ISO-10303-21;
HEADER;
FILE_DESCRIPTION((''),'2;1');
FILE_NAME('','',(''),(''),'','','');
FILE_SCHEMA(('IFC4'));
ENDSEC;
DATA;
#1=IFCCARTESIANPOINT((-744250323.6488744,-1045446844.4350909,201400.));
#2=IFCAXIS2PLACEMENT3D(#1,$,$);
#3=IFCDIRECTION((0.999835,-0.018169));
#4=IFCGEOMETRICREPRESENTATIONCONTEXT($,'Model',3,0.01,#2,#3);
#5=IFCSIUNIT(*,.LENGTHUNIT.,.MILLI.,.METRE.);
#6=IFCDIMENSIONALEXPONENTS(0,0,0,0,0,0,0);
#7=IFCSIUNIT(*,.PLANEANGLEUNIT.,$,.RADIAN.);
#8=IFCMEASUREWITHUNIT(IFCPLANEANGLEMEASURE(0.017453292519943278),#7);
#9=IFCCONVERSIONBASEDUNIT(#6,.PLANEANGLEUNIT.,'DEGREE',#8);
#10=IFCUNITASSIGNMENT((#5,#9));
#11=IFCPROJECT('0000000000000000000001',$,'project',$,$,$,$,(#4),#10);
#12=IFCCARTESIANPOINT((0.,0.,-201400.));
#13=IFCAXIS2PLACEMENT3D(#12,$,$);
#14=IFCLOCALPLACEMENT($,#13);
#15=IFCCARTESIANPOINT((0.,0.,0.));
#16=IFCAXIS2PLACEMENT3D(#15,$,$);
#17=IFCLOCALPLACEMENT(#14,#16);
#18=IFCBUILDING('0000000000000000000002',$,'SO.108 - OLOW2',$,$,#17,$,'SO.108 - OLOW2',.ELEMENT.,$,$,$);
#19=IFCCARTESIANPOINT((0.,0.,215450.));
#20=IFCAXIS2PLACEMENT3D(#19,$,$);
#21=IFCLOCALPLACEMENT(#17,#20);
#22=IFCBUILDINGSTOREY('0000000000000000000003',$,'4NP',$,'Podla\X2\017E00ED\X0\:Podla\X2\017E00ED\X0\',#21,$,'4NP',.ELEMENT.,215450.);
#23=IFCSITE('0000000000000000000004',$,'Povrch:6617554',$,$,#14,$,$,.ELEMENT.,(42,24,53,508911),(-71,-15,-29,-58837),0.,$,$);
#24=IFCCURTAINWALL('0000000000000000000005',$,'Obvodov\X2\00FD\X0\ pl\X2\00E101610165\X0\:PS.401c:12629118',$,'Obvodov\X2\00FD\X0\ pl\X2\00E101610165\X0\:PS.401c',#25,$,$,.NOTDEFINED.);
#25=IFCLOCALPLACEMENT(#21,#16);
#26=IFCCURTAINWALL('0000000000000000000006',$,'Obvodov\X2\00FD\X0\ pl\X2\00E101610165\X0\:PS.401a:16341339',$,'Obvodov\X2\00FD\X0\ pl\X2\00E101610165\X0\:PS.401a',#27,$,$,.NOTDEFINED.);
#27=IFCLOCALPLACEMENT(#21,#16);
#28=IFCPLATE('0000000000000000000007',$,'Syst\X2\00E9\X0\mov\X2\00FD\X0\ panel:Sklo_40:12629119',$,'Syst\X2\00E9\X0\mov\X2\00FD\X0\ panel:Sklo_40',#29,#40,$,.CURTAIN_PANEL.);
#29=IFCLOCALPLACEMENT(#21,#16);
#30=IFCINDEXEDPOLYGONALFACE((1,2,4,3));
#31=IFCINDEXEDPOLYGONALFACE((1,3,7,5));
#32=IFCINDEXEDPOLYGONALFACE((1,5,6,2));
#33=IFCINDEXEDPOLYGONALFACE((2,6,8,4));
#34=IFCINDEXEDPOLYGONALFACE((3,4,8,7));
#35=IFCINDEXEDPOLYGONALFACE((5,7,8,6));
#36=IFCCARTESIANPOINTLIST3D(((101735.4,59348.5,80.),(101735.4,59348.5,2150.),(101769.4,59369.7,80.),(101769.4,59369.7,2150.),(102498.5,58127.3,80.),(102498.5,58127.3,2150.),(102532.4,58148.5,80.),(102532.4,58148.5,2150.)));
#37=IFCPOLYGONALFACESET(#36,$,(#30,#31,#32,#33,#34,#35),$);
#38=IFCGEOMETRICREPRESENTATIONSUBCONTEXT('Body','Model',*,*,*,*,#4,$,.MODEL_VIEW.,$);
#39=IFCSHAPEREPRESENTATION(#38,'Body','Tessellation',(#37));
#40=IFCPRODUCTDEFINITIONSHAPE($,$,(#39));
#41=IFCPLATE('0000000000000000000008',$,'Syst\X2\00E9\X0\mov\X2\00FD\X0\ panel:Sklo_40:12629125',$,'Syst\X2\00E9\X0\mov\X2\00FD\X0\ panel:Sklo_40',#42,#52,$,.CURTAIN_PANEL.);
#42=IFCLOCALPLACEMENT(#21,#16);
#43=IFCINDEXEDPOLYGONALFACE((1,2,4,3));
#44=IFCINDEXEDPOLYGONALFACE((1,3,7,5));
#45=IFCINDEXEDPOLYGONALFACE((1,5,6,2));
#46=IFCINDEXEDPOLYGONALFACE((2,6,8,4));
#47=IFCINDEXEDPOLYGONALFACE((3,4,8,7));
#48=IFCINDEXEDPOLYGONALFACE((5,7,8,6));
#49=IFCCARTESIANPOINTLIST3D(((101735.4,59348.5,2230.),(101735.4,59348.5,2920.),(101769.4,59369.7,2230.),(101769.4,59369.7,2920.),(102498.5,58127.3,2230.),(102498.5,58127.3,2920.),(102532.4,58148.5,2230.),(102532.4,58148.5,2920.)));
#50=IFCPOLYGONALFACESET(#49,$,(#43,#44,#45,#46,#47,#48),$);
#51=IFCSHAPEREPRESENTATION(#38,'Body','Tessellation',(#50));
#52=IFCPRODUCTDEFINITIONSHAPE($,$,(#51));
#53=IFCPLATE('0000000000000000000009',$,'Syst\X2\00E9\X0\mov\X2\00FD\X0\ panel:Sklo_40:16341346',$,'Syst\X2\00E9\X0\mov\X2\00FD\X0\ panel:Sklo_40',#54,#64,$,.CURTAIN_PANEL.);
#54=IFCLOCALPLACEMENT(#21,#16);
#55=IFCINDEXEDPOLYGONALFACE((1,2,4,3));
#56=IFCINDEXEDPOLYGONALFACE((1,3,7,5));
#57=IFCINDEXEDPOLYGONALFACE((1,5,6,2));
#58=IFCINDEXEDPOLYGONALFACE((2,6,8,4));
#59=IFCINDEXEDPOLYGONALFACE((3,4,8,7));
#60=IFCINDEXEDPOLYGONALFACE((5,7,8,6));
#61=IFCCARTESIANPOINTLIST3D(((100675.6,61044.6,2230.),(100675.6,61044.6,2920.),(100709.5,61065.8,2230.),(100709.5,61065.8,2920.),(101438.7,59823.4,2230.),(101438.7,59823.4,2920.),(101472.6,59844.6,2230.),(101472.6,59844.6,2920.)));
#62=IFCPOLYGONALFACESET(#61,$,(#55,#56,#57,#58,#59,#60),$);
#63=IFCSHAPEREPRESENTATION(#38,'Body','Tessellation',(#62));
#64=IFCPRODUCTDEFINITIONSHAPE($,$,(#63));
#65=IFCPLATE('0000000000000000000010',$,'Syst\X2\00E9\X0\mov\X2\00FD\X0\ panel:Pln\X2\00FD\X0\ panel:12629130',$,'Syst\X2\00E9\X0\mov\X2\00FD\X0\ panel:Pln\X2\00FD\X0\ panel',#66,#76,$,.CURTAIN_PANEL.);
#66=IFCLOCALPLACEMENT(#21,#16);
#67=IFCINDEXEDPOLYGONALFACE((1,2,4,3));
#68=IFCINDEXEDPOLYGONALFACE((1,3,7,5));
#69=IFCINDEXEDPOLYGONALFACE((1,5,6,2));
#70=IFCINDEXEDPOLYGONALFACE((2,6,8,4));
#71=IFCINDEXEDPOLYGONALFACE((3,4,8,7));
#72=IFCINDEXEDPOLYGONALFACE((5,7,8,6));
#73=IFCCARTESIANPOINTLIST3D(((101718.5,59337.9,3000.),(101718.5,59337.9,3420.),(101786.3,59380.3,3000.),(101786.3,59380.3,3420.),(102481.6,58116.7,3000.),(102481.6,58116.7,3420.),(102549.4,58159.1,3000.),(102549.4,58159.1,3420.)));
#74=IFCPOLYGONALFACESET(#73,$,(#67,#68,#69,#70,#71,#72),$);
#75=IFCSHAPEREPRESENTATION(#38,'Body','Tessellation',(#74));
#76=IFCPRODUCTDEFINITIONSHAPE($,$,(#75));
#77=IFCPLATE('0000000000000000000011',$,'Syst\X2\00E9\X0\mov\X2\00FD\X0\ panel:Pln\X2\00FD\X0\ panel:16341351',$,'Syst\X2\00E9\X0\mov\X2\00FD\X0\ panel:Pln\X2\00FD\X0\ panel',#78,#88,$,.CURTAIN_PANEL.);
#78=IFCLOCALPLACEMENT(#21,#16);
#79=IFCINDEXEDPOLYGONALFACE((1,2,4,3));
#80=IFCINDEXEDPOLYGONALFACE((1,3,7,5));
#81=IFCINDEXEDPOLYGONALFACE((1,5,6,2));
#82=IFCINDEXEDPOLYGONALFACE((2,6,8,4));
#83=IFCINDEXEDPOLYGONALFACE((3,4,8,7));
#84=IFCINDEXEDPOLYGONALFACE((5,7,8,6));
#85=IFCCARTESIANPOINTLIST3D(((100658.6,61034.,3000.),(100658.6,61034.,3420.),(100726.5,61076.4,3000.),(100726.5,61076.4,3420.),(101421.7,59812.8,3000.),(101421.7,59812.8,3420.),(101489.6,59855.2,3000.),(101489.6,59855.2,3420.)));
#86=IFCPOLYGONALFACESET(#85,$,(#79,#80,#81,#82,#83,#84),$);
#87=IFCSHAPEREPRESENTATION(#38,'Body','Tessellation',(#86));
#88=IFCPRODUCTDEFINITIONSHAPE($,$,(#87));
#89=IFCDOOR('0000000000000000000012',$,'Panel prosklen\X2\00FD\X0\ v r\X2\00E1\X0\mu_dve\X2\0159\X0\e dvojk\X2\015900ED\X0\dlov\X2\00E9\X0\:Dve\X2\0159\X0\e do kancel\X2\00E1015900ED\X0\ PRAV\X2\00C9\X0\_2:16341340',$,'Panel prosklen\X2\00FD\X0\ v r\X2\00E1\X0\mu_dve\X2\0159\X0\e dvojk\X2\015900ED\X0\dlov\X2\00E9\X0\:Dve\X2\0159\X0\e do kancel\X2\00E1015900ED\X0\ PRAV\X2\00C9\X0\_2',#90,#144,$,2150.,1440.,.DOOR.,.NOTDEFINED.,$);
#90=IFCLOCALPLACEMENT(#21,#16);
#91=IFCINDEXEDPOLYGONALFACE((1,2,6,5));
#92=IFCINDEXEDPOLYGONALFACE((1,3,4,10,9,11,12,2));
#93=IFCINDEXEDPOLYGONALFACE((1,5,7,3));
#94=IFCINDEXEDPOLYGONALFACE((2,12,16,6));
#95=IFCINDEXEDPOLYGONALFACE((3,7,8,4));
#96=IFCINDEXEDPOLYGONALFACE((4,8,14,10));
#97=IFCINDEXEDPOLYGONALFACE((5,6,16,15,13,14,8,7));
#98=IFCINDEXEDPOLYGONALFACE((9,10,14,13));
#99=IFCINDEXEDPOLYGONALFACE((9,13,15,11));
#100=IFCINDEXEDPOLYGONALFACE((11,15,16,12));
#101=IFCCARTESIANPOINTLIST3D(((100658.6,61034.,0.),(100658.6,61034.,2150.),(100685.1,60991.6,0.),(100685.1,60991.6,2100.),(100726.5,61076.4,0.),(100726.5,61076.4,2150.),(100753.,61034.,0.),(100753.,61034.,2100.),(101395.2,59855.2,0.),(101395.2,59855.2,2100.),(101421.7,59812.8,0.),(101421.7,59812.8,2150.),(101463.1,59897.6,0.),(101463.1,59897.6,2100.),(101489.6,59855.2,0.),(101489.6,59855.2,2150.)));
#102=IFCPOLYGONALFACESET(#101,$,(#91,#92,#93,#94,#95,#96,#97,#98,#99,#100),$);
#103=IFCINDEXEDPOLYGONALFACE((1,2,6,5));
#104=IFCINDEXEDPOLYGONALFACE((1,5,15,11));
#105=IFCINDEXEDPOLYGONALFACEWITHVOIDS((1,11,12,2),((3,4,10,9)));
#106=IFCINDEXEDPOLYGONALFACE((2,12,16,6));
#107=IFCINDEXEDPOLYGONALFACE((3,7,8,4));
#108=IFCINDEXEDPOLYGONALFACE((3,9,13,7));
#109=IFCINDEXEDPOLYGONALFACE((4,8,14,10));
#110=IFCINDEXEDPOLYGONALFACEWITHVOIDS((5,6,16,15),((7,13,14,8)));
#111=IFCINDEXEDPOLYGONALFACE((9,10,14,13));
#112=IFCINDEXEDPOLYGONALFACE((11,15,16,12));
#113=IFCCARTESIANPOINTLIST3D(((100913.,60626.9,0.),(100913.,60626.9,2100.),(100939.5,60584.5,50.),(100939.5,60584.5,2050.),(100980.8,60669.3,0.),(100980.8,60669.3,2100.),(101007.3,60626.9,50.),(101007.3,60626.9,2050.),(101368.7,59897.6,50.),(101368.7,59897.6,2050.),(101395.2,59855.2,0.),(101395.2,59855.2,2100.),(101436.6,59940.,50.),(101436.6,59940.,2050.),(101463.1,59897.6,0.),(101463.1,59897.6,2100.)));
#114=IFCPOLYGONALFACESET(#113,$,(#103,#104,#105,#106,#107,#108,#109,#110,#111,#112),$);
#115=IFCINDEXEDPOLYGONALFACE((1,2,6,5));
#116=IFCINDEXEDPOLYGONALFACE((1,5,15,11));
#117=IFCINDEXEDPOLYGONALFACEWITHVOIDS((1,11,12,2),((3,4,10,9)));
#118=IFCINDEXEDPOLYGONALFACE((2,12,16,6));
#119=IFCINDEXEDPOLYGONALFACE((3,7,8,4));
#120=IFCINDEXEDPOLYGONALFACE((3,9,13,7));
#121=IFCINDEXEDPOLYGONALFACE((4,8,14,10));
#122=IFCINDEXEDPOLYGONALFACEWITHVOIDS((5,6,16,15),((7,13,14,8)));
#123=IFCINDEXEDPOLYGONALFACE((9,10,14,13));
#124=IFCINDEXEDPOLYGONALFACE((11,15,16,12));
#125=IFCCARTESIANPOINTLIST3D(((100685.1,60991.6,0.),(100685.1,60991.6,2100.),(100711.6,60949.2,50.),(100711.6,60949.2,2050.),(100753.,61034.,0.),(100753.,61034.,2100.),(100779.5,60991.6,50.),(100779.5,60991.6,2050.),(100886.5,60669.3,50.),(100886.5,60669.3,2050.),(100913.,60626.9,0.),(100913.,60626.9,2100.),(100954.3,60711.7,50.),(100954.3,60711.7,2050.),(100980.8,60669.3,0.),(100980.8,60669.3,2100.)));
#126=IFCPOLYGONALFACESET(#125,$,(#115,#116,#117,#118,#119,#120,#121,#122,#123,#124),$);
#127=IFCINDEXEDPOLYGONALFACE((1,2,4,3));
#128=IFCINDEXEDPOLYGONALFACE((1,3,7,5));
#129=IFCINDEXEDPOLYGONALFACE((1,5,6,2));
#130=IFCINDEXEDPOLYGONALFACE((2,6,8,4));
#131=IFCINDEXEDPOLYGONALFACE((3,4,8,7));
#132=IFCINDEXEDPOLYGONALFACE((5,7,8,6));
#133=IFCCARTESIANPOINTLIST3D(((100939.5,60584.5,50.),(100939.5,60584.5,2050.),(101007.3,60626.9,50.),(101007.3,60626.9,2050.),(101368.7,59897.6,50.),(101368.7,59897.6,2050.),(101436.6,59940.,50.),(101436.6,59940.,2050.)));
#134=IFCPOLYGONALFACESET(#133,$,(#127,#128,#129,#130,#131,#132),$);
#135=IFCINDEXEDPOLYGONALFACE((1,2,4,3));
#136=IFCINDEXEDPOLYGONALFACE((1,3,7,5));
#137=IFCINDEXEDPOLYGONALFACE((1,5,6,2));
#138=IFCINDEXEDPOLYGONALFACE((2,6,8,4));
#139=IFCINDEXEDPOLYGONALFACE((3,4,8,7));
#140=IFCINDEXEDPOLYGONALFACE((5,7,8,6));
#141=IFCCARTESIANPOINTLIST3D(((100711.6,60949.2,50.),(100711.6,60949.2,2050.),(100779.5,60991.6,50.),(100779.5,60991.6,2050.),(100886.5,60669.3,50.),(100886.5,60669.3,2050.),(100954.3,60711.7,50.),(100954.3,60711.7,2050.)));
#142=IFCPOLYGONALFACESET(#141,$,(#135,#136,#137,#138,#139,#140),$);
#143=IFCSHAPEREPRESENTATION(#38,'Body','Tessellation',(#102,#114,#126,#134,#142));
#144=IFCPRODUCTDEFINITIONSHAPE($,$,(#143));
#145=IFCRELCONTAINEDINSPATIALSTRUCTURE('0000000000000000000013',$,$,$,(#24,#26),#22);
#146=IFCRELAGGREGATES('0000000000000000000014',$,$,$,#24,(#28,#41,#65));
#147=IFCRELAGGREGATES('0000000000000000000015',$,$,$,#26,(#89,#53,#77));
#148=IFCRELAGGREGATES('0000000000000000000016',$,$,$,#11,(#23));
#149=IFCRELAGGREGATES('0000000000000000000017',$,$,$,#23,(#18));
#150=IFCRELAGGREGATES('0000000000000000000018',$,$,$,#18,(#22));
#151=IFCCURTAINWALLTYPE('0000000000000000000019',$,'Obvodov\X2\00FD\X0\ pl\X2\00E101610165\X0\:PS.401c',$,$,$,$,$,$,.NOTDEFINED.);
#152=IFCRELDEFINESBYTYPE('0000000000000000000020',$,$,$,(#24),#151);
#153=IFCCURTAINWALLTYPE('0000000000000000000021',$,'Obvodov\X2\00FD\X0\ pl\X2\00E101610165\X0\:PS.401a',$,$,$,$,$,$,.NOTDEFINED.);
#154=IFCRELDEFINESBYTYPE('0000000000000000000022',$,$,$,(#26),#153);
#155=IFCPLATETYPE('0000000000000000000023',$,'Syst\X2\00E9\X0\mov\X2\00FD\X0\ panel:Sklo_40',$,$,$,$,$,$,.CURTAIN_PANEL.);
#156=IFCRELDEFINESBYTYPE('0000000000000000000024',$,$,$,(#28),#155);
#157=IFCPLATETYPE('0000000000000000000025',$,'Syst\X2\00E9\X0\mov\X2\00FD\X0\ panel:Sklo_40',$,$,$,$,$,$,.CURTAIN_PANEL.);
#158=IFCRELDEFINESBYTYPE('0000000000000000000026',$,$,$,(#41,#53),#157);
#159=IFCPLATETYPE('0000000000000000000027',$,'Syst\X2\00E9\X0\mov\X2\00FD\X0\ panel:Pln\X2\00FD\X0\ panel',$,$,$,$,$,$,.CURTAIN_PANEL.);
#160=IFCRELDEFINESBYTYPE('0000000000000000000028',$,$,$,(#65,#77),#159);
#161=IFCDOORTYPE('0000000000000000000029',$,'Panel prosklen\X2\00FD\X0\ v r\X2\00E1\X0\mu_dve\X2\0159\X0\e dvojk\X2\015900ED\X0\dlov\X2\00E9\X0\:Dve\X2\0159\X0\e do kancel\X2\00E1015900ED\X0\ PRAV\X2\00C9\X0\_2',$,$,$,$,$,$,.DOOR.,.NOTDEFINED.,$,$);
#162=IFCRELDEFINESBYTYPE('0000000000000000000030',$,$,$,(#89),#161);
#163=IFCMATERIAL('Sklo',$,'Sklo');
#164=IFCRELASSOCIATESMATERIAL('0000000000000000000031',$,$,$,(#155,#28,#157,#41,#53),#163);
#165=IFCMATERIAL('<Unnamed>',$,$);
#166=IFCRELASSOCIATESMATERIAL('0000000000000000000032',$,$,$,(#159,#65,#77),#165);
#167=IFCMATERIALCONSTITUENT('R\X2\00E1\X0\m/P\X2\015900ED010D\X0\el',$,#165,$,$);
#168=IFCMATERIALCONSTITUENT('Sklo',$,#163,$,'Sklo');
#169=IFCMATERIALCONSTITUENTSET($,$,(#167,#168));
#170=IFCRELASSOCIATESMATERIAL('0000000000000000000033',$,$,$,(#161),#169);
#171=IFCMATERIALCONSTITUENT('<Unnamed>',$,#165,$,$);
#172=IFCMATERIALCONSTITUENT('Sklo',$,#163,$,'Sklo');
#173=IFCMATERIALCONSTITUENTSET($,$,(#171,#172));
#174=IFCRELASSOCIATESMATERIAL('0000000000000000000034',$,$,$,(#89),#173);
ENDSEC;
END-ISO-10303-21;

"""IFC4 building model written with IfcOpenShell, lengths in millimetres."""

from ifc_helpers import new_model, entity, si_unit, converted_unit, direction, frame, origin, place, context, subcontext, project, spatial, indexed_curve, outline, extrude, source, transform, mapped, material, constituent, constituent_set, type_object, type_shapes, element, aggregate, save


model = new_model("IFC4")

# Units and contexts
model_context = context("Model", 3, precision=0.01, world=frame((-744250323.6488744, -1045446844.4350909, 201400.0)), true_north=direction((0.999835, -0.018169)))
body_context = subcontext(model_context, "Body", "Model", "MODEL_VIEW")
ifc_project = project(units=[si_unit("LENGTHUNIT", "METRE", prefix="MILLI"), converted_unit("PLANEANGLEUNIT", "DEGREE", entity("IfcPlaneAngleMeasure", 0.017453292519943278), si_unit("PLANEANGLEUNIT", "RADIAN"), dimensions=[0, 0, 0, 0, 0, 0, 0])], contexts=[model_context])

# Site, building, storey
site_placement = place(None, frame((0.0, 0.0, -201400.0)))
site = spatial("IfcSite", under=ifc_project, at=site_placement, Name="Povrch:6617554", CompositionType="ELEMENT", RefLatitude=(42, 24, 53, 508911), RefLongitude=(-71, -15, -29, -58837), RefElevation=0.0)
building_placement = place(site_placement, origin())
building = spatial("IfcBuilding", under=site, at=building_placement, Name="SO.108 - OLOW2", LongName="SO.108 - OLOW2", CompositionType="ELEMENT")
storey_placement = place(building_placement, frame((0.0, 0.0, 215450.0)))
storey = spatial("IfcBuildingStorey", under=building, at=storey_placement, Name="4NP", ObjectType="Podlaží:Podlaží", LongName="4NP", CompositionType="ELEMENT", Elevation=215450.0)

# Curtain walls
curtain_wall_type_1 = type_object("IfcCurtainWallType", Name="Obvodový plášť:PS.401c", PredefinedType="NOTDEFINED")
curtain_wall_1_placement = place(storey_placement, frame((0.0, 0.0, -215450.0)))
curtain_wall_1 = element("IfcCurtainWall", 1, at=curtain_wall_1_placement, inside=storey, type_object=curtain_wall_type_1, Name="Obvodový plášť:PS.401c:12629118", ObjectType="Obvodový plášť:PS.401c", PredefinedType="NOTDEFINED")
ifc_material_1 = material(Name="<Unnamed>")
curtain_wall_type_2 = type_object("IfcCurtainWallType", Name="Obvodový plášť:PS.401a", PredefinedType="NOTDEFINED")
curtain_wall_2_placement = place(storey_placement, frame((0.0, 0.0, -215450.0)))
curtain_wall_2 = element("IfcCurtainWall", 2, at=curtain_wall_2_placement, inside=storey, type_object=curtain_wall_type_2, Name="Obvodový plášť:PS.401a:16341339", ObjectType="Obvodový plášť:PS.401a", PredefinedType="NOTDEFINED")

# Plates
ifc_material_2 = material(Name="Sklo", Category="Sklo")
plate_type_1 = type_object("IfcPlateType", Name="Systémový panel:Sklo_40", PredefinedType="CURTAIN_PANEL", material=ifc_material_2)
shared_shape_1 = source(origin(), body_context, "Body", "SweptSolid", [
    extrude(outline(indexed_curve([(-20.0, -720.0), (20.0, -720.0), (20.0, 720.0), (-20.0, 720.0), (-20.0, -720.0)], self_intersect=False)), frame((0.0, 0.0, 0.0), z_axis=(0.0, 0.0, 1.0), x_axis=(0.0, 1.0, 0.0)), (0.0, 0.0, 1.0), 2070.0),
])
type_shapes(plate_type_1, [shared_shape_1])
plate_1_placement = place(curtain_wall_1_placement, frame((102133.9, 58748.5, 215530.0), z_axis=(0.0, 0.0, 1.0), x_axis=(0.529919, -0.848048, 0.0)))
plate_1 = element("IfcPlate", 3, at=plate_1_placement, type_object=plate_type_1, material=ifc_material_2, Name="Systémový panel:Sklo_40:12629119", ObjectType="Systémový panel:Sklo_40", PredefinedType="CURTAIN_PANEL", context=body_context, shape_type="MappedRepresentation", body=[
    mapped(shared_shape_1, transform((0.0, 0.0, 0.0), scale=1.0)),
])
plate_type_2 = type_object("IfcPlateType", Name="Systémový panel:Sklo_40", PredefinedType="CURTAIN_PANEL", material=ifc_material_2)
shared_shape_2 = source(origin(), body_context, "Body", "SweptSolid", [
    extrude(outline(indexed_curve([(-20.0, -720.0), (20.0, -720.0), (20.0, 720.0), (-20.0, 720.0), (-20.0, -720.0)], self_intersect=False)), frame((0.0, 0.0, 0.0), z_axis=(0.0, 0.0, 1.0), x_axis=(0.0, 1.0, 0.0)), (0.0, 0.0, 1.0), 690.0),
])
type_shapes(plate_type_2, [shared_shape_2])
plate_2_placement = place(curtain_wall_1_placement, frame((102133.9, 58748.5, 217680.0), z_axis=(0.0, 0.0, 1.0), x_axis=(0.529919, -0.848048, 0.0)))
plate_2 = element("IfcPlate", 4, at=plate_2_placement, type_object=plate_type_2, material=ifc_material_2, Name="Systémový panel:Sklo_40:12629125", ObjectType="Systémový panel:Sklo_40", PredefinedType="CURTAIN_PANEL", context=body_context, shape_type="MappedRepresentation", body=[
    mapped(shared_shape_2, transform((0.0, 0.0, 0.0), scale=1.0)),
])
plate_3_placement = place(curtain_wall_2_placement, frame((101074.1, 60444.6, 217680.0), z_axis=(0.0, 0.0, 1.0), x_axis=(-0.529919, 0.848048, 0.0)))
plate_3 = element("IfcPlate", 5, at=plate_3_placement, type_object=plate_type_2, material=ifc_material_2, Name="Systémový panel:Sklo_40:16341346", ObjectType="Systémový panel:Sklo_40", PredefinedType="CURTAIN_PANEL", context=body_context, shape_type="MappedRepresentation", body=[
    mapped(shared_shape_2, transform((0.0, 0.0, 0.0), scale=1.0)),
])
plate_type_3 = type_object("IfcPlateType", Name="Systémový panel:Plný panel", PredefinedType="CURTAIN_PANEL", material=ifc_material_1)
shared_shape_3 = source(origin(), body_context, "Body", "SweptSolid", [
    extrude(outline(indexed_curve([(-40.0, -720.0), (40.0, -720.0), (40.0, 720.0), (-40.0, 720.0), (-40.0, -720.0)], self_intersect=False)), frame((0.0, 0.0, 0.0), z_axis=(0.0, 0.0, 1.0), x_axis=(0.0, 1.0, 0.0)), (0.0, 0.0, 1.0), 420.0),
])
type_shapes(plate_type_3, [shared_shape_3])
plate_4_placement = place(curtain_wall_1_placement, frame((102133.9, 58748.5, 218450.0), z_axis=(0.0, 0.0, 1.0), x_axis=(0.529919, -0.848048, 0.0)))
plate_4 = element("IfcPlate", 6, at=plate_4_placement, type_object=plate_type_3, material=ifc_material_1, Name="Systémový panel:Plný panel:12629130", ObjectType="Systémový panel:Plný panel", PredefinedType="CURTAIN_PANEL", context=body_context, shape_type="MappedRepresentation", body=[
    mapped(shared_shape_3, transform((0.0, 0.0, 0.0), scale=1.0)),
])
aggregate(curtain_wall_1, [plate_1, plate_2, plate_4])
plate_5_placement = place(curtain_wall_2_placement, frame((101074.1, 60444.6, 218450.0), z_axis=(0.0, 0.0, 1.0), x_axis=(-0.529919, 0.848048, 0.0)))
plate_5 = element("IfcPlate", 7, at=plate_5_placement, type_object=plate_type_3, material=ifc_material_1, Name="Systémový panel:Plný panel:16341351", ObjectType="Systémový panel:Plný panel", PredefinedType="CURTAIN_PANEL", context=body_context, shape_type="MappedRepresentation", body=[
    mapped(shared_shape_3, transform((0.0, 0.0, 0.0), scale=1.0)),
])

# Door
ifc_constituent_1 = constituent(ifc_material_1, Name="<Unnamed>")
ifc_constituent_2 = constituent(ifc_material_2, Name="Sklo", Category="Sklo")
ifc_constituent_set_1 = constituent_set(constituents=[ifc_constituent_1, ifc_constituent_2])
ifc_constituent_3 = constituent(ifc_material_1, Name="Rám/Příčel")
ifc_constituent_4 = constituent(ifc_material_2, Name="Sklo", Category="Sklo")
ifc_constituent_set_2 = constituent_set(constituents=[ifc_constituent_3, ifc_constituent_4])
door_type = type_object("IfcDoorType", Name="Panel prosklený v rámu_dveře dvojkřídlové:Dveře do kanceláří PRAVÉ_2", OperationType="NOTDEFINED", PredefinedType="DOOR", material=ifc_constituent_set_2)
shared_shape_4 = source(origin(), body_context, "Body", "SweptSolid", [
    extrude(outline(indexed_curve([(-720.0, -1087.5), (720.0, -1087.5), (720.0, 1062.5), (670.0, 1062.5), (670.0, -1037.5), (-670.0, -1037.5), (-670.0, 1062.5), (-720.0, 1062.5), (-720.0, -1087.5)], self_intersect=False)), frame((0.0, -40.0, 1062.5), z_axis=(0.0, 1.0, 0.0), x_axis=(1.0, 0.0, 0.0)), (0.0, 0.0, 1.0), 80.0),
    extrude(outline(indexed_curve([(-1050.0, -455.0), (1050.0, -455.0), (1050.0, 455.0), (-1050.0, 455.0), (-1050.0, -455.0)], self_intersect=False), holes=[indexed_curve([(-1000.0, -405.0), (-1000.0, 405.0), (1000.0, 405.0), (1000.0, -405.0), (-1000.0, -405.0)], self_intersect=False)]), frame((215.0, -40.0, 1050.0), z_axis=(0.0, 1.0, 0.0), x_axis=(0.0, 0.0, -1.0)), (0.0, 0.0, 1.0), 80.0),
    extrude(outline(indexed_curve([(-1050.0, -215.0), (1050.0, -215.0), (1050.0, 215.0), (-1050.0, 215.0), (-1050.0, -215.0)], self_intersect=False), holes=[indexed_curve([(-1000.0, -165.0), (-1000.0, 165.0), (1000.0, 165.0), (1000.0, -165.0), (-1000.0, -165.0)], self_intersect=False)]), frame((-455.0, -40.0, 1050.0), z_axis=(0.0, 1.0, 0.0), x_axis=(0.0, 0.0, -1.0)), (0.0, 0.0, 1.0), 80.0),
    extrude(outline(indexed_curve([(-40.0, -405.0), (40.0, -405.0), (40.0, 405.0), (-40.0, 405.0), (-40.0, -405.0)], self_intersect=False)), frame((215.0, 0.0, 50.0), z_axis=(0.0, 0.0, 1.0), x_axis=(0.0, 1.0, 0.0)), (0.0, 0.0, 1.0), 2000.0),
    extrude(outline(indexed_curve([(-40.0, -165.0), (40.0, -165.0), (40.0, 165.0), (-40.0, 165.0), (-40.0, -165.0)], self_intersect=False)), frame((-455.0, 0.0, 50.0), z_axis=(0.0, 0.0, 1.0), x_axis=(0.0, 1.0, 0.0)), (0.0, 0.0, 1.0), 2000.0),
])
type_shapes(door_type, [shared_shape_4])
door_placement = place(curtain_wall_2_placement, frame((101074.1, 60444.6, 215450.0), z_axis=(0.0, 0.0, 1.0), x_axis=(0.529919, -0.848048, 0.0)))
door = element("IfcDoor", 8, at=door_placement, type_object=door_type, material=ifc_constituent_set_1, Name="Panel prosklený v rámu_dveře dvojkřídlové:Dveře do kanceláří PRAVÉ_2:16341340", ObjectType="Panel prosklený v rámu_dveře dvojkřídlové:Dveře do kanceláří PRAVÉ_2", OperationType="NOTDEFINED", OverallHeight=2150.0, OverallWidth=1440.0, PredefinedType="DOOR", context=body_context, shape_type="MappedRepresentation", body=[
    mapped(shared_shape_4, transform((0.0, 0.0, 0.0), scale=1.0)),
])
aggregate(curtain_wall_2, [door, plate_3, plate_5])

save(model, "model.ifc")
